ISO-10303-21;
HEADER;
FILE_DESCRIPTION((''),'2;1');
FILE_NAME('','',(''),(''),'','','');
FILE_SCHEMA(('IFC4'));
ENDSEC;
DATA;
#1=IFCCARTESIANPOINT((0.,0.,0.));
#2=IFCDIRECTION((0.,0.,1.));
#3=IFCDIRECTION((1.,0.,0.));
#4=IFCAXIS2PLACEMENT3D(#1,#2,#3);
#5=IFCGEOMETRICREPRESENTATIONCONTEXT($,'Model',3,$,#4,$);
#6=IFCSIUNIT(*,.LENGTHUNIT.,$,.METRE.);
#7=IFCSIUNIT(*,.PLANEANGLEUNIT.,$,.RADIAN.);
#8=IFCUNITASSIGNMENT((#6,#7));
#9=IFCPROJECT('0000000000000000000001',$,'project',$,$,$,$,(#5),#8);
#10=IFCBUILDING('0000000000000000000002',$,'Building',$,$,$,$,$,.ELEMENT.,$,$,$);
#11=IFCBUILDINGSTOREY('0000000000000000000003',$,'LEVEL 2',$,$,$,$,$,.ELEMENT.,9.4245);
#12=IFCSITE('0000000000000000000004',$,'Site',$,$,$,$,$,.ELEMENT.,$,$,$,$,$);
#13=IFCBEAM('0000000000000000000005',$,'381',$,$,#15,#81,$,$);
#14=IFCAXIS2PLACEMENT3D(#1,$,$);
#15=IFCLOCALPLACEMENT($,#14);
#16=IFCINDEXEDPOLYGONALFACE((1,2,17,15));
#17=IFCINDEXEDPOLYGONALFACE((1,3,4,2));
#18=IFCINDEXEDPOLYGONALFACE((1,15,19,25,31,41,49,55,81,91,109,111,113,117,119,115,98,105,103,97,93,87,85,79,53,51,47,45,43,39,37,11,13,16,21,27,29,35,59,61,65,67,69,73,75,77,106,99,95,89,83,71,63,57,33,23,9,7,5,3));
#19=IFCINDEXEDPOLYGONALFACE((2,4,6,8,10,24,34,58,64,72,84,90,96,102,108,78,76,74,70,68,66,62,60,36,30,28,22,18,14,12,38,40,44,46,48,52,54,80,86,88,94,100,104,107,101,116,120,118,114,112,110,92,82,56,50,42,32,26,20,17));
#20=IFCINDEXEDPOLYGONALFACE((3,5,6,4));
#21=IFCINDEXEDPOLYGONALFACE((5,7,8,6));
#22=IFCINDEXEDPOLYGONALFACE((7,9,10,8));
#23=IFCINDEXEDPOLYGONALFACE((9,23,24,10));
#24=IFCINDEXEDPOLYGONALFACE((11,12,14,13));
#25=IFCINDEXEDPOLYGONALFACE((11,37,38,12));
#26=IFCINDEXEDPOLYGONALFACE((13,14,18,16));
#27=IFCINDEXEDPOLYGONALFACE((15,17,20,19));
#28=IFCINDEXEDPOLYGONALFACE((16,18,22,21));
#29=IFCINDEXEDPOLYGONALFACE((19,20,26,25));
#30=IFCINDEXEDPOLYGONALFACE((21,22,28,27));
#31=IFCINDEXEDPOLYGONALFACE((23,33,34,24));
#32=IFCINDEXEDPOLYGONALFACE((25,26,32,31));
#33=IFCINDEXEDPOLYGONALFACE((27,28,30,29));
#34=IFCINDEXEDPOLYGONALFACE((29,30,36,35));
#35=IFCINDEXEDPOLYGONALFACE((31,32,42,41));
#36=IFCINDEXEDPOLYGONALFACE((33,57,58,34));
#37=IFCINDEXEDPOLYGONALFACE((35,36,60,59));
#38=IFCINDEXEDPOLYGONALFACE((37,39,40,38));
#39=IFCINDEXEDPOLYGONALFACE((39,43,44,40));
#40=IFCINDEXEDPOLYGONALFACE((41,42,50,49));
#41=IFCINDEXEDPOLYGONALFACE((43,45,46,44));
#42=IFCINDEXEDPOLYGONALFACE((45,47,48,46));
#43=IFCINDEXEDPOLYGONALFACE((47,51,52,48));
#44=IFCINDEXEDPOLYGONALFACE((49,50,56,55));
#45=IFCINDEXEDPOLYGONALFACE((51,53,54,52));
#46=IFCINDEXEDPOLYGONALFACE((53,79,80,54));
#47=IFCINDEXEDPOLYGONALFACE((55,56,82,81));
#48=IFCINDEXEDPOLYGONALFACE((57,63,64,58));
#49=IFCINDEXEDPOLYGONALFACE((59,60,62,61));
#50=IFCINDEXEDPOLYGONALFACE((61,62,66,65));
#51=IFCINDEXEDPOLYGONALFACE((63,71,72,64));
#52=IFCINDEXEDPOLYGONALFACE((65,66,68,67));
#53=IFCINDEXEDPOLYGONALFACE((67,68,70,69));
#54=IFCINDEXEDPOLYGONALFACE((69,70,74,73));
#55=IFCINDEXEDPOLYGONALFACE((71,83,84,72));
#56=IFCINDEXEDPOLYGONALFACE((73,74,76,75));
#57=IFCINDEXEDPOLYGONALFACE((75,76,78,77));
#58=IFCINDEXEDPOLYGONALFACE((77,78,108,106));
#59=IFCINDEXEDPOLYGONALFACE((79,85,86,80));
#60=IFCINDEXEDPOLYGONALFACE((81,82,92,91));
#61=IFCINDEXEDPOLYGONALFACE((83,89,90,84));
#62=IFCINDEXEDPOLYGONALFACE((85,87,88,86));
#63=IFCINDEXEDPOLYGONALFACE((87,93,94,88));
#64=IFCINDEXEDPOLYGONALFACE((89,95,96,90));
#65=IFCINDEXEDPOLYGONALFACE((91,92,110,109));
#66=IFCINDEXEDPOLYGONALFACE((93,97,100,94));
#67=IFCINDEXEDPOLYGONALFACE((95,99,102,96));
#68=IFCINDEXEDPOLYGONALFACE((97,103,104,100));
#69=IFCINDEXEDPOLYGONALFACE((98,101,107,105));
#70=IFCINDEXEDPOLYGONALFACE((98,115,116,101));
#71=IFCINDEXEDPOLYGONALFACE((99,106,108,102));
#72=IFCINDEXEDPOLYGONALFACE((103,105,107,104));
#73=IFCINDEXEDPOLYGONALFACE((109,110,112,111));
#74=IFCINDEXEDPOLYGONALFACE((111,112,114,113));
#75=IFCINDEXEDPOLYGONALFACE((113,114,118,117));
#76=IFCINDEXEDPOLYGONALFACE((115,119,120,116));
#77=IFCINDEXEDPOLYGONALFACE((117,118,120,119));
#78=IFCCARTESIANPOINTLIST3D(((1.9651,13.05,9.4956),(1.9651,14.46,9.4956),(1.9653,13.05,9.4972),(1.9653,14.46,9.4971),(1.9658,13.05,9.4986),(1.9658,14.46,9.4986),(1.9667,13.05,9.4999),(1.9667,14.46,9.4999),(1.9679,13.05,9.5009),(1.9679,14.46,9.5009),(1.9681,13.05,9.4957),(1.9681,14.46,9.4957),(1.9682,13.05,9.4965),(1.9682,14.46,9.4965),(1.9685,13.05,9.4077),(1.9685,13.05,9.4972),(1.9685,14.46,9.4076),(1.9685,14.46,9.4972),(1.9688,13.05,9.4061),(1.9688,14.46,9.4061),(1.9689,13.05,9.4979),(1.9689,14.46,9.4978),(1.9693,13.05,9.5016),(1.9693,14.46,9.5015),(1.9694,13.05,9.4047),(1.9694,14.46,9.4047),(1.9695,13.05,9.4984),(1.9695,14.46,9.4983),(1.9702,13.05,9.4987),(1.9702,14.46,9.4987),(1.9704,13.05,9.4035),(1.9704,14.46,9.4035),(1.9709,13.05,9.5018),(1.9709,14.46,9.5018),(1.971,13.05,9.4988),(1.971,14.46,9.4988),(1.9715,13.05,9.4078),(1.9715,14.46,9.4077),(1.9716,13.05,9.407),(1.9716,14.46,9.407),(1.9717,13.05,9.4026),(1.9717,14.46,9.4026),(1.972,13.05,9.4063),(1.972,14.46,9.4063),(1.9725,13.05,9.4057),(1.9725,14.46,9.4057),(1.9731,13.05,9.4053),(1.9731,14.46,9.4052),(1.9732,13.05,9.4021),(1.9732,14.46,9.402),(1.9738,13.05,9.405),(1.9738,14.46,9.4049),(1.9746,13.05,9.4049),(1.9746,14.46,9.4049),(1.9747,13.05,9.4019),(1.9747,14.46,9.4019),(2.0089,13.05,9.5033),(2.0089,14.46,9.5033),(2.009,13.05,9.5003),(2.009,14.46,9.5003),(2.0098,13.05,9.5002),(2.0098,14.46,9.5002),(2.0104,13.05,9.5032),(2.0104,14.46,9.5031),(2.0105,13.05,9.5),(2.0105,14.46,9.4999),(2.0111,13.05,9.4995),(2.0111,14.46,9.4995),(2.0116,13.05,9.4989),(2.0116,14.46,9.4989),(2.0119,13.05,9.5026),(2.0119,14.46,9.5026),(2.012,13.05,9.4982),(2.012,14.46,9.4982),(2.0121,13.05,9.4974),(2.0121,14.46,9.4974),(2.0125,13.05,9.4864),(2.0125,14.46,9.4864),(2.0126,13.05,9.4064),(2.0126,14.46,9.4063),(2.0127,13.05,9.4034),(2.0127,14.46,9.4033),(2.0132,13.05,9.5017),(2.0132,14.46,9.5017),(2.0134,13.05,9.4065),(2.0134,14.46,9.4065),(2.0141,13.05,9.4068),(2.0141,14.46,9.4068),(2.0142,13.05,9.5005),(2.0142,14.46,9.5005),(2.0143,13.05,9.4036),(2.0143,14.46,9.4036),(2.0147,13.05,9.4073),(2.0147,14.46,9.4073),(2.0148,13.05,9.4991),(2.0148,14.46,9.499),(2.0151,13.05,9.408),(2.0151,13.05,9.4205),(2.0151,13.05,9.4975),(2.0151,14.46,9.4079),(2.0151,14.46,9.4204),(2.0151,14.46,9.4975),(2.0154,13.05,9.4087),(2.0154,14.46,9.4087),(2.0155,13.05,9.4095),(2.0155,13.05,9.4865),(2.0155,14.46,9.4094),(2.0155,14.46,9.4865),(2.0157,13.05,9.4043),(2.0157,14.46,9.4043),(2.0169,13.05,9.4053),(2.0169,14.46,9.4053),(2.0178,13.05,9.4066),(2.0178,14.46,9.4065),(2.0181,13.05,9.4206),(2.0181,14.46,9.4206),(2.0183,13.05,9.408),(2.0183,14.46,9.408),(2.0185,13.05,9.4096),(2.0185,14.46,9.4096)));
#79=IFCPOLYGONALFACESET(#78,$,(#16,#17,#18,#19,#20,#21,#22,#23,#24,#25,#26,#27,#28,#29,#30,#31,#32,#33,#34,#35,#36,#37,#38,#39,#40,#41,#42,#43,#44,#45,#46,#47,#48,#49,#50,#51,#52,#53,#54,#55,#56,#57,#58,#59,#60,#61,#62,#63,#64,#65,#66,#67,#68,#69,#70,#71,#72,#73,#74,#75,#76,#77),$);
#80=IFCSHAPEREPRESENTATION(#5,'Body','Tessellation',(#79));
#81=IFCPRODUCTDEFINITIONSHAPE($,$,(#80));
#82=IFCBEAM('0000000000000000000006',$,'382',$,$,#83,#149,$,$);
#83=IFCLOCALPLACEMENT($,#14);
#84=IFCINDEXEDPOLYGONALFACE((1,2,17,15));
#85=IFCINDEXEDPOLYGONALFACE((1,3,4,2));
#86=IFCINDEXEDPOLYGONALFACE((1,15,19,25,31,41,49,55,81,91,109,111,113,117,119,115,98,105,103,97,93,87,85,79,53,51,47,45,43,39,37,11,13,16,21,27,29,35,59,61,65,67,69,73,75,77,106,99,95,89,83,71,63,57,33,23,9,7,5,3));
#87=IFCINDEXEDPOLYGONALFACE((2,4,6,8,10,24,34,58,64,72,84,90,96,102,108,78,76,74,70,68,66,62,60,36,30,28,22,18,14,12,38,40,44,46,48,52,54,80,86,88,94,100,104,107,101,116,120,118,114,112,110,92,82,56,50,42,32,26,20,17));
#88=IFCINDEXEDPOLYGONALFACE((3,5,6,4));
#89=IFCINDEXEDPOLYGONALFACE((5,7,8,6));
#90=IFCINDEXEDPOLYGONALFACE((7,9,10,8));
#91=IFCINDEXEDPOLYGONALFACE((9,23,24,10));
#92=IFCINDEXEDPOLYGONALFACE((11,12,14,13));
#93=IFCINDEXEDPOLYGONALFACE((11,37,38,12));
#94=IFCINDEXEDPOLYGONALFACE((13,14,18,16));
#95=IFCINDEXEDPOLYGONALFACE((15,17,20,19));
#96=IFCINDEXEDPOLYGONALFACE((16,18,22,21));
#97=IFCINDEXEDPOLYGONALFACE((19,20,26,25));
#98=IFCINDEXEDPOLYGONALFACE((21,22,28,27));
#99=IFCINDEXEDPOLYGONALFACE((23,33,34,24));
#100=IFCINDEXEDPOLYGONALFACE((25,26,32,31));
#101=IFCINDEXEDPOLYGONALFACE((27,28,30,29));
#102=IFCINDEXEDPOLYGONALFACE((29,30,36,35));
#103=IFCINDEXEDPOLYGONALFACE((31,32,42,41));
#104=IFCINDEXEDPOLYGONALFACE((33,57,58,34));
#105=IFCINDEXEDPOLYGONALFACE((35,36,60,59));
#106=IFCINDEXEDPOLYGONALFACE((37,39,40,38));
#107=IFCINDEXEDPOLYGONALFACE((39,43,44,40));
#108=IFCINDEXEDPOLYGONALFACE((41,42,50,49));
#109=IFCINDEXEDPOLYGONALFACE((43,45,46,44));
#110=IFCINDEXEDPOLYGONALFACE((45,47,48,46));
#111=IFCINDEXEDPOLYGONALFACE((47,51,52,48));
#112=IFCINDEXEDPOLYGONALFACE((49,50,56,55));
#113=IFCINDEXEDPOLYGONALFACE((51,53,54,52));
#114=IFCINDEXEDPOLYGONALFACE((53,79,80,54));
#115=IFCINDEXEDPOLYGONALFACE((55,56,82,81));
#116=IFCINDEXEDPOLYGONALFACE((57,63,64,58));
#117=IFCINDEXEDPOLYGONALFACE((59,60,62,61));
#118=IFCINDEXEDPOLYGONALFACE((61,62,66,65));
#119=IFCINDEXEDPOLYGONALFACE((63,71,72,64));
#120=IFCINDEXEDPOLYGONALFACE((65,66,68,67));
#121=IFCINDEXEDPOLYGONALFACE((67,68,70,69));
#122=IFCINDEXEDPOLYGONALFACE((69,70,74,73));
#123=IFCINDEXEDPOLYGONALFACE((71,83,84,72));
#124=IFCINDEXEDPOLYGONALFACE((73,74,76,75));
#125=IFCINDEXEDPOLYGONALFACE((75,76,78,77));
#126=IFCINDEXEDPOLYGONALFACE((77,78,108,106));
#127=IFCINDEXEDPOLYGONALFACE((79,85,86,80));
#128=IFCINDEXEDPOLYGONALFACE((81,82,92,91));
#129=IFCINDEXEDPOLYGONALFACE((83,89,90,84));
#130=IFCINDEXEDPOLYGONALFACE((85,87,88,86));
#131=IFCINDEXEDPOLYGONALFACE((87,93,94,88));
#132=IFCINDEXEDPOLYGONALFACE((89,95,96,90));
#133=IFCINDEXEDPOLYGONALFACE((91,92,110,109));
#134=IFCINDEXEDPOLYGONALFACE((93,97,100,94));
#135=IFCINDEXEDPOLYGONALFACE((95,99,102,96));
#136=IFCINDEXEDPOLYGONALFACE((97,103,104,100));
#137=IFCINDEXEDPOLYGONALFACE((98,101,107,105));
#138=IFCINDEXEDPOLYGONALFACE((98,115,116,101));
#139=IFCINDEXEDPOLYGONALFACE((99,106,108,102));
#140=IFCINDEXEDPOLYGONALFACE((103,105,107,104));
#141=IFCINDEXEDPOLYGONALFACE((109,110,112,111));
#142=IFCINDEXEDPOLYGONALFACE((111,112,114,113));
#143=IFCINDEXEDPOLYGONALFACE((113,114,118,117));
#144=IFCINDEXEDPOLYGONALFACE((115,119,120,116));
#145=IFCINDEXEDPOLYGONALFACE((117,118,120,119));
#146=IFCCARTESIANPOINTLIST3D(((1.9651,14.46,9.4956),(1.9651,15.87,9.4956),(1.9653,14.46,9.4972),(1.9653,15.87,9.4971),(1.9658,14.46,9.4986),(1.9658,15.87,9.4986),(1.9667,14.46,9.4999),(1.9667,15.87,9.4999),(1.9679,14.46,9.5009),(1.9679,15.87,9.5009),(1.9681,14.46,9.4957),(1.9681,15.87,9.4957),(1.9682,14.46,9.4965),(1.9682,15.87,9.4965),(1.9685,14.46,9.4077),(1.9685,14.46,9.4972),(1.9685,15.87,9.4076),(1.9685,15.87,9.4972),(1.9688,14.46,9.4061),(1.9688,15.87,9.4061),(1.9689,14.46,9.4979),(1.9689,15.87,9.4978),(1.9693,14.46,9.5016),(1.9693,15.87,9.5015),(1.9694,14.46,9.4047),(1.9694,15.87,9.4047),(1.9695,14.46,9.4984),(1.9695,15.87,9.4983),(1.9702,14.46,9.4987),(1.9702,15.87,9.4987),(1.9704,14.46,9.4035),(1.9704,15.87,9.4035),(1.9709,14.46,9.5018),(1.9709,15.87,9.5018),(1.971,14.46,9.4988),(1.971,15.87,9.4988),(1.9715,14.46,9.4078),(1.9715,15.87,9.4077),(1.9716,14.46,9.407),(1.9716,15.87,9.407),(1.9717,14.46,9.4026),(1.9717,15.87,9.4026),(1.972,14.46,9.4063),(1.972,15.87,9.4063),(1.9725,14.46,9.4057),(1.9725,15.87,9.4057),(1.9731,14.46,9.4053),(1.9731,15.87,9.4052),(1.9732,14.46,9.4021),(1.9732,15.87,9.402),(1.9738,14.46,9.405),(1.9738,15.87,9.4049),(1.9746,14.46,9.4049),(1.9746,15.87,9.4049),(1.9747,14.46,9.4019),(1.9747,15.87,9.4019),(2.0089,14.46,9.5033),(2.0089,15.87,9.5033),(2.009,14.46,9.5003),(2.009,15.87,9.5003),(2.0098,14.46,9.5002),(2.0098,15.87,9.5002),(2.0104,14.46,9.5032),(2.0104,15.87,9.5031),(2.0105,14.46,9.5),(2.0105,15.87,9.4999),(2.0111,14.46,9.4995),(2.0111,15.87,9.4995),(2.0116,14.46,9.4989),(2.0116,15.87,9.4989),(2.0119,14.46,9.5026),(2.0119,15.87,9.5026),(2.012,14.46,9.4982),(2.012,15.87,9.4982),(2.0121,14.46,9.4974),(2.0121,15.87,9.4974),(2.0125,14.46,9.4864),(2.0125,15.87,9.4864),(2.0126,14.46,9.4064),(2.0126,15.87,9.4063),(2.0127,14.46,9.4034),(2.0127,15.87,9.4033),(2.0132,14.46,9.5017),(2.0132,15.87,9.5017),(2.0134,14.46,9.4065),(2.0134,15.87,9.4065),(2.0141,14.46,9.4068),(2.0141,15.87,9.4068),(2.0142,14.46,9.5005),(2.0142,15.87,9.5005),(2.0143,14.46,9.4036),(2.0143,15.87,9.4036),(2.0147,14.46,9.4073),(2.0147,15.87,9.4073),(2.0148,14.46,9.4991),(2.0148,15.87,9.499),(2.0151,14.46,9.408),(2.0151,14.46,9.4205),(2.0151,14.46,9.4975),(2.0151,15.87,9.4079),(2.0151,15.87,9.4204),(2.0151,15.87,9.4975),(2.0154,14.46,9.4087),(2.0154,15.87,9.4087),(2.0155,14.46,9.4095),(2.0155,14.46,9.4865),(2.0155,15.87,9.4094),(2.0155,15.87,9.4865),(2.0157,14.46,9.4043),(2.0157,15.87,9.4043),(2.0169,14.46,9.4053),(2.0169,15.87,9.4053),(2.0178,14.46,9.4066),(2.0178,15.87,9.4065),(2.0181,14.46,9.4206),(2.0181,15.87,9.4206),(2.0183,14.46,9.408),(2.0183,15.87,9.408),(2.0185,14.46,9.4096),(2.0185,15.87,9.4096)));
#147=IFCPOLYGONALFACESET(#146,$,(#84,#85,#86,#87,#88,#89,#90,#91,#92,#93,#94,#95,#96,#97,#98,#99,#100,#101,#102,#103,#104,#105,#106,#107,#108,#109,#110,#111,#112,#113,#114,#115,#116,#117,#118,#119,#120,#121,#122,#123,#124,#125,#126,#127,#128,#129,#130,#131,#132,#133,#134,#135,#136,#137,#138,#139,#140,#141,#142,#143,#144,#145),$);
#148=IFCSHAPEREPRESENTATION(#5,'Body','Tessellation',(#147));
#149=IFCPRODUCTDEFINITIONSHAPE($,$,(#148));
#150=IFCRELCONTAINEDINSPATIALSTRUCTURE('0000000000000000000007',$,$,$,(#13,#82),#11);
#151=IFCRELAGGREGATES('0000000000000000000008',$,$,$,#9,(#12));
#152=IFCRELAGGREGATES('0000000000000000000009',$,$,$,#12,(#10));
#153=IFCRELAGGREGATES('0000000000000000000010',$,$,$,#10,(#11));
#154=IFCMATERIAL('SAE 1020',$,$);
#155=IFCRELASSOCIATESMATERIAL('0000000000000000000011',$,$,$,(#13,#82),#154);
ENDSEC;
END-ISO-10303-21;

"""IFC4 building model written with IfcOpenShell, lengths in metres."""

from ifc_helpers import new_model, si_unit, frame, origin_with_axes, origin_2d_with_axis, place, context, project, spatial, c_section, extrude, material, material_profile, profile_set, profile_usage, element, save


model = new_model("IFC4")

# Units and contexts
model_context = context("Model", 3, world=origin_with_axes())
ifc_project = project(units=[si_unit("LENGTHUNIT", "METRE"), si_unit("PLANEANGLEUNIT", "RADIAN")], contexts=[model_context])

# Site, building, storey
site = spatial("IfcSite", under=ifc_project, Name="Site", CompositionType="ELEMENT")
building = spatial("IfcBuilding", under=site, Name="Building", CompositionType="ELEMENT")
storey = spatial("IfcBuildingStorey", under=building, Name="LEVEL 2", CompositionType="ELEMENT", Elevation=9.4245)

# Beams
ifc_material = material(Name="SAE 1020")
ifc_material_profile_1 = material_profile(ifc_material, c_section(Depth=0.1, Width=0.05, WallThickness=0.003, Girth=0.017, InternalFilletRadius=0.003, at=origin_2d_with_axis()))
ifc_profile_set_1 = profile_set([ifc_material_profile_1])
ifc_profile_usage_1 = profile_usage(ifc_profile_set_1, cardinal=10)
beam_1_placement = place(None, frame((1.9918, 13.05, 9.4526), z_axis=(0.0, 1.0, -0.00003), x_axis=(0.999256, 0.000001, 0.038562)))
element("IfcBeam", 1, at=beam_1_placement, inside=storey, material=ifc_profile_usage_1, Name="381", context=model_context, shape_type="SweptSolid", body=[
    extrude(c_section(Depth=0.1, Width=0.05, WallThickness=0.003, Girth=0.017, InternalFilletRadius=0.003, at=origin_2d_with_axis()), origin_with_axes(), (0.0, 0.0, 1.0), 1.41),
])
ifc_material_profile_2 = material_profile(ifc_material, c_section(Depth=0.1, Width=0.05, WallThickness=0.003, Girth=0.017, InternalFilletRadius=0.003, at=origin_2d_with_axis()))
ifc_profile_set_2 = profile_set([ifc_material_profile_2])
ifc_profile_usage_2 = profile_usage(ifc_profile_set_2, cardinal=10)
beam_2_placement = place(None, frame((1.9918, 14.46, 9.4526), z_axis=(0.0, 1.0, -0.00003), x_axis=(0.999256, 0.000001, 0.038562)))
element("IfcBeam", 2, at=beam_2_placement, inside=storey, material=ifc_profile_usage_2, Name="382", context=model_context, shape_type="SweptSolid", body=[
    extrude(c_section(Depth=0.1, Width=0.05, WallThickness=0.003, Girth=0.017, InternalFilletRadius=0.003, at=origin_2d_with_axis()), origin_with_axes(), (0.0, 0.0, 1.0), 1.41),
])

save(model, "model.ifc")
